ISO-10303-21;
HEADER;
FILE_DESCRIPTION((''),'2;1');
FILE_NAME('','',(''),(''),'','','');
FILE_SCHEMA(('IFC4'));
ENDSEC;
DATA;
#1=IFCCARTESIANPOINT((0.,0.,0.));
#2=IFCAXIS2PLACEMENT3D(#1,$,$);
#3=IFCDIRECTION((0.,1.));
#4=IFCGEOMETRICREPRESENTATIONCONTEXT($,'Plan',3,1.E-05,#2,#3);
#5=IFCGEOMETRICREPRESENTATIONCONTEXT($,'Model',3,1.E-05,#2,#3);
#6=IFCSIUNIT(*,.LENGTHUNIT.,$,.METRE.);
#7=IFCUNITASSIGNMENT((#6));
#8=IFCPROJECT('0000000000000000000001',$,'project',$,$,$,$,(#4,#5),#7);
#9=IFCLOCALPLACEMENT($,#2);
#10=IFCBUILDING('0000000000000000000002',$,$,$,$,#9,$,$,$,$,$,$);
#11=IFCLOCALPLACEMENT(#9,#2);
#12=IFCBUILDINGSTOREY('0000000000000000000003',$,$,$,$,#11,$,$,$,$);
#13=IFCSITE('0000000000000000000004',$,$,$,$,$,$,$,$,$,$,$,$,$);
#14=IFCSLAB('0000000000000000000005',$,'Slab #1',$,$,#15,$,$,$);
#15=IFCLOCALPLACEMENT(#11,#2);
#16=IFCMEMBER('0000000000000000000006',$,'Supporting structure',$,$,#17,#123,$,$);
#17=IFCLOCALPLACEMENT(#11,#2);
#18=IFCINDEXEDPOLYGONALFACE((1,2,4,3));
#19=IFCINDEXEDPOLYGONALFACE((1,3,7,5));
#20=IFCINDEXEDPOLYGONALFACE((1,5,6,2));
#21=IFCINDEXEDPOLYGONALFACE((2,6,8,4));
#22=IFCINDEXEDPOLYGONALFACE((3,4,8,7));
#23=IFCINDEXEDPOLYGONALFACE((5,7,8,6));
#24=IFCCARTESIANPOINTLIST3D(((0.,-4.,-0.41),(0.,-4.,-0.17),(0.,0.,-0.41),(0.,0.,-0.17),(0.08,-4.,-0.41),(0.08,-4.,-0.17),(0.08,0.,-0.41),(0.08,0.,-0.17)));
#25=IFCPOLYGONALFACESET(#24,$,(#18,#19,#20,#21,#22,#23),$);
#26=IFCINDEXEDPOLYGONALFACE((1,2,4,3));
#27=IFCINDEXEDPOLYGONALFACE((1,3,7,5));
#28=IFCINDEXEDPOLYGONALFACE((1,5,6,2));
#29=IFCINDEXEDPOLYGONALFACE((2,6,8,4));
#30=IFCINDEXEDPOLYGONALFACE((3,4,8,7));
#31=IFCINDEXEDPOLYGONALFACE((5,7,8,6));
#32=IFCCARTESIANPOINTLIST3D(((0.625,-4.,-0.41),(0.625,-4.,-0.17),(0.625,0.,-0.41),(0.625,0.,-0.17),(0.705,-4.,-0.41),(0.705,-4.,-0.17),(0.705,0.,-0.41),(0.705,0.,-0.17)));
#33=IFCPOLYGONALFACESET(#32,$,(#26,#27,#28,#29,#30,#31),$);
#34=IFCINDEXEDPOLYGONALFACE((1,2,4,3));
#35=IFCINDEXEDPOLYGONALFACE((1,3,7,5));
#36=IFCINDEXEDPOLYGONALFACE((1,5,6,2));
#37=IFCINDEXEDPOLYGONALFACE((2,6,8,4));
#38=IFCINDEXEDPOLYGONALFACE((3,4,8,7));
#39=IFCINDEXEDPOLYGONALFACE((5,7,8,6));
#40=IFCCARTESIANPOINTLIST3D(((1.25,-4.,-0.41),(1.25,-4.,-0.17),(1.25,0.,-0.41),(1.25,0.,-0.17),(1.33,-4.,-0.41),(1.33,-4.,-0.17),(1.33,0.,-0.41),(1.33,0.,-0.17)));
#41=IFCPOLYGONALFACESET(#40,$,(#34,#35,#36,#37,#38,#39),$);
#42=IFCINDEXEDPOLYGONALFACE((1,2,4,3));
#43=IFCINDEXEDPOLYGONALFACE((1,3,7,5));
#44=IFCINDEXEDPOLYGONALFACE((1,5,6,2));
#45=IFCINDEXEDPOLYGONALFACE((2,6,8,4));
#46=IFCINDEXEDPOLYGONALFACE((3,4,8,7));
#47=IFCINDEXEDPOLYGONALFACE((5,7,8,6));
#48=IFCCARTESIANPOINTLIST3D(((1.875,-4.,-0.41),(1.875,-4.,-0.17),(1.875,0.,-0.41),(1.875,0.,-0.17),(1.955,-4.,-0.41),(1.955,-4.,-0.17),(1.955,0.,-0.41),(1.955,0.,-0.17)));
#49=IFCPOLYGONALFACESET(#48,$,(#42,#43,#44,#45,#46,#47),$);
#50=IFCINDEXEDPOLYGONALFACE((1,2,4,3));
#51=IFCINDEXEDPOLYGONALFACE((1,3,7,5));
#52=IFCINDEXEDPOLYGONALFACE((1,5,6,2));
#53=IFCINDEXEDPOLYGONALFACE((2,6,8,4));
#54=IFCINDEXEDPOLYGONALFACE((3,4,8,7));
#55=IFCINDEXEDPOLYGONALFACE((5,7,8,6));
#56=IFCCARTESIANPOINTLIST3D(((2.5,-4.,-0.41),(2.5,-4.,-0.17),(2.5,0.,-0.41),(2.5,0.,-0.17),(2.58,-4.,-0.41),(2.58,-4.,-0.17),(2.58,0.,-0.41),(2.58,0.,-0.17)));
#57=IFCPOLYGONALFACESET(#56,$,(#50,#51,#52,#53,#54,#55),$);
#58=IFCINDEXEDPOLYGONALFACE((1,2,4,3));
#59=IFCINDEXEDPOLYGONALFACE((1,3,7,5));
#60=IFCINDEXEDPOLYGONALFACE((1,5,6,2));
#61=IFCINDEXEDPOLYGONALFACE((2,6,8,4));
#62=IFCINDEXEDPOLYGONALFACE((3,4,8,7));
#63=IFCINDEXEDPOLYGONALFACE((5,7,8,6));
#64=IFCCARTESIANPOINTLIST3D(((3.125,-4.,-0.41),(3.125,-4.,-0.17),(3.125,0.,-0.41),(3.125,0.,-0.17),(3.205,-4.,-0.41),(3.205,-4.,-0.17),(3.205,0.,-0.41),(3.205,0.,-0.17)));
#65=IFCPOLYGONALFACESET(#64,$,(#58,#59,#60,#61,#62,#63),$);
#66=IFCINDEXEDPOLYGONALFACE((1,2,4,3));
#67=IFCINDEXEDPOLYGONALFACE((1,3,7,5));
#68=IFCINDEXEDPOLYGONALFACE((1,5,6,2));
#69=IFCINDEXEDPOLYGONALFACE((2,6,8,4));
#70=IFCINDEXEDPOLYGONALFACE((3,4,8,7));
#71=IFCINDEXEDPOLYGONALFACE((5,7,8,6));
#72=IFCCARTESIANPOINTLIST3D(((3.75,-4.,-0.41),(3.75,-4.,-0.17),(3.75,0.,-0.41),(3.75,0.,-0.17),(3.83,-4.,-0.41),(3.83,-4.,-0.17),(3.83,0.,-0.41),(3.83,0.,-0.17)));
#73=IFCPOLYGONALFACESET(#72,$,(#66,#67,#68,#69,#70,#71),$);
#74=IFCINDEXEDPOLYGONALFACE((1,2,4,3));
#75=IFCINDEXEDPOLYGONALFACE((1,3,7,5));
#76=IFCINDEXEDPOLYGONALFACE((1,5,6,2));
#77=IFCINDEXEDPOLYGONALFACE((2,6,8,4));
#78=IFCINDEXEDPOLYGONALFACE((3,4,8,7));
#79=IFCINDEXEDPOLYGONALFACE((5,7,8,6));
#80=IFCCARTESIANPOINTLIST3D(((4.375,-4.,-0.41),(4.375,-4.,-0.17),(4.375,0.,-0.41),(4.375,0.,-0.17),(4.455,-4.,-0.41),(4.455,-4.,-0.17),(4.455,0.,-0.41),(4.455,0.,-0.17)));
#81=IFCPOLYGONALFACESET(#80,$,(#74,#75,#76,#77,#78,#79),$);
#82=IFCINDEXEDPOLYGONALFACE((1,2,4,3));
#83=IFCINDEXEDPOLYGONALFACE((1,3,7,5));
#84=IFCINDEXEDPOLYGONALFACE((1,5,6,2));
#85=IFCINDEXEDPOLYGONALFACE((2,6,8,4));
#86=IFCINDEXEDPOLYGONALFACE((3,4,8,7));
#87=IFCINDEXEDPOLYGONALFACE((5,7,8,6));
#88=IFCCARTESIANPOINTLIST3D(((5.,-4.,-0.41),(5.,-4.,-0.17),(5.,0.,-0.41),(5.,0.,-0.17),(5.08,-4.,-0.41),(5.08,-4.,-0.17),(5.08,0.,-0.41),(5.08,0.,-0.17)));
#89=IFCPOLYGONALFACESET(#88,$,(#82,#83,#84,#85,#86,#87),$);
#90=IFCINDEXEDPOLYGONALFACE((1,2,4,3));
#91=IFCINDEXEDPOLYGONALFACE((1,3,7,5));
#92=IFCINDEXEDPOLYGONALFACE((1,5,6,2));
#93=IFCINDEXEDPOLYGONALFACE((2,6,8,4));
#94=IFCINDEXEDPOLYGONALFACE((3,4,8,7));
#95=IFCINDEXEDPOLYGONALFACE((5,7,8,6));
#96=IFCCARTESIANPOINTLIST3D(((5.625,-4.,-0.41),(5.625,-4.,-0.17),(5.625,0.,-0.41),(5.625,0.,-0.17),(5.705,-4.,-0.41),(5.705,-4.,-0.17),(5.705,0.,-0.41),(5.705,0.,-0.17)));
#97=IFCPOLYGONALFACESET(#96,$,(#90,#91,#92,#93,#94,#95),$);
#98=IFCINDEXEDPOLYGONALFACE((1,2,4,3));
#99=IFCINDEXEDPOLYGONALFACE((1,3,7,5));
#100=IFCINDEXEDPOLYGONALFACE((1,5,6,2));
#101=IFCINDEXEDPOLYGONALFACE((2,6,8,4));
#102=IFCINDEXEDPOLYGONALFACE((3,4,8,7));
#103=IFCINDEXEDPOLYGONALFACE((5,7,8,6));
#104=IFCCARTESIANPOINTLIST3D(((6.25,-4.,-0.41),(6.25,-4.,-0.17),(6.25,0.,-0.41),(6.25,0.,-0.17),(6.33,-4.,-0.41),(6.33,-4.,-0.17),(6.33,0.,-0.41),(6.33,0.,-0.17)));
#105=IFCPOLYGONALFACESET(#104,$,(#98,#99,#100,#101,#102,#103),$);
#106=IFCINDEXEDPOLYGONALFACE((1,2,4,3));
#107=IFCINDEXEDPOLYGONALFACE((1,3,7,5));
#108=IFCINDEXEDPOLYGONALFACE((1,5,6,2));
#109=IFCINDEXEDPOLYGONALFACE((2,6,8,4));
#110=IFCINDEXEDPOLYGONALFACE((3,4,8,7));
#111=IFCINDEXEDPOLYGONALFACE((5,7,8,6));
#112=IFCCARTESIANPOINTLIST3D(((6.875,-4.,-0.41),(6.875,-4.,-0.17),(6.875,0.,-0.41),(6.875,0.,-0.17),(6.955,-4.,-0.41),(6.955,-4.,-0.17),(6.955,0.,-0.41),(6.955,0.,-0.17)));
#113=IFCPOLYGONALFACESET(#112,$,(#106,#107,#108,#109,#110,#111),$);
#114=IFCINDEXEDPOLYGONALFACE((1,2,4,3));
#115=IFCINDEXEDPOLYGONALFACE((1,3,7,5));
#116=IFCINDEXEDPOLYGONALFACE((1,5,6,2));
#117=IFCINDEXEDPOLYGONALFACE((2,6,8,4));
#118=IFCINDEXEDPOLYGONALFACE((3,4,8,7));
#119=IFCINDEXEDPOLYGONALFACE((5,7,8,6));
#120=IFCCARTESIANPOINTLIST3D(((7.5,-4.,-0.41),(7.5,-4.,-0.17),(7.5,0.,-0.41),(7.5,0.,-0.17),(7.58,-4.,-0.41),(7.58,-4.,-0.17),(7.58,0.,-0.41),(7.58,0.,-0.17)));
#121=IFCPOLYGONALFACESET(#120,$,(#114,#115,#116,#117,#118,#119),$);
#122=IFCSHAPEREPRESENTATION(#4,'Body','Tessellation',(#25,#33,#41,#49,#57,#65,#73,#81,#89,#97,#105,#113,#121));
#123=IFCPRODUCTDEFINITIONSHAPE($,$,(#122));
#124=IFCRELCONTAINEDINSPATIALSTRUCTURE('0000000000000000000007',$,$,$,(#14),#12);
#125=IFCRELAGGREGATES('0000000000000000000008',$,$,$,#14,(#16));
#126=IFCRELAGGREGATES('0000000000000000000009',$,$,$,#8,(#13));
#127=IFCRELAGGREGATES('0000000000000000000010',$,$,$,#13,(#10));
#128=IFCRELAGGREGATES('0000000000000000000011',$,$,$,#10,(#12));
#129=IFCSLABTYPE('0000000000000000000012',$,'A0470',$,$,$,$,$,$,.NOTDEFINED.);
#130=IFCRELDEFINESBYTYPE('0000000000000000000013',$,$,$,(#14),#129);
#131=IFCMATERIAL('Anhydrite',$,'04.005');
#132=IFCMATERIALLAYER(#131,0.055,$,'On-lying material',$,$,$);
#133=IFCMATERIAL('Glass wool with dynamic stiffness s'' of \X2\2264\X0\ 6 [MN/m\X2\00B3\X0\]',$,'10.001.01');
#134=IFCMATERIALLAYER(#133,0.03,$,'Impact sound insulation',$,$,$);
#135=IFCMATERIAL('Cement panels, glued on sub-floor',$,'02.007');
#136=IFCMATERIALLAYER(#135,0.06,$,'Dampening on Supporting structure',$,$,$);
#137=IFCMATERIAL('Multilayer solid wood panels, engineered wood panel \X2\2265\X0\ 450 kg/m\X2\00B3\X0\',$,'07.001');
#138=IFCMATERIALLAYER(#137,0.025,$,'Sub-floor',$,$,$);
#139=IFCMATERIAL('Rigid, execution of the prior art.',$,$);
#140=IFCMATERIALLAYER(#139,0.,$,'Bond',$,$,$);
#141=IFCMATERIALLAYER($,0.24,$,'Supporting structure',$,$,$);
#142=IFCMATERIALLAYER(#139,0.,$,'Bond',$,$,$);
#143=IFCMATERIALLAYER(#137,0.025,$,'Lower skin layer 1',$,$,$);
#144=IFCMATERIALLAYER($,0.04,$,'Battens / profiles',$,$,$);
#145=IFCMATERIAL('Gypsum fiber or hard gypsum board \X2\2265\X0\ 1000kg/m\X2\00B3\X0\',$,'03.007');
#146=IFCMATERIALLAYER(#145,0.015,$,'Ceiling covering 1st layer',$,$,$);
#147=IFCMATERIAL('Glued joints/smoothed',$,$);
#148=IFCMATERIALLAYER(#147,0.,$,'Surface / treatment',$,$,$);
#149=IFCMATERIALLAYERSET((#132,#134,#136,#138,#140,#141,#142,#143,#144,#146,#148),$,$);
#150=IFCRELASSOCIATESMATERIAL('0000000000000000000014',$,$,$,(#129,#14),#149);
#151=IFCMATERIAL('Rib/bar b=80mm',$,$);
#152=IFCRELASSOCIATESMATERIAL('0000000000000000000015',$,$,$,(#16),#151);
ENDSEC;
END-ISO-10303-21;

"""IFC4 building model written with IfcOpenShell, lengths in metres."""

from ifc_helpers import new_model, si_unit, direction, frame, frame_2d, origin, place, context, project, spatial, rectangle, extrude, material, layer, layer_set, type_object, element, aggregate, save


model = new_model("IFC4")

# Units and contexts
plan_context = context("Plan", 3, precision=1e-05, world=origin(), true_north=direction((0.0, 1.0)))
model_context = context("Model", 3, precision=1e-05, world=origin(), true_north=direction((0.0, 1.0)))
ifc_project = project(units=[si_unit("LENGTHUNIT", "METRE")], contexts=[plan_context, model_context])

# Site, building, storey
site = spatial("IfcSite", under=ifc_project)
building_placement = place(None, origin())
building = spatial("IfcBuilding", under=site, at=building_placement)
storey_placement = place(building_placement, origin())
storey = spatial("IfcBuildingStorey", under=building, at=storey_placement)

# Slab, member
ifc_material_1 = material(Name="Anhydrite", Category="04.005")
ifc_layer_1 = layer(ifc_material_1, 0.055, Name="On-lying material")
ifc_material_2 = material(Name="Glass wool with dynamic stiffness s' of ≤ 6 [MN/m³]", Category="10.001.01")
ifc_layer_2 = layer(ifc_material_2, 0.03, Name="Impact sound insulation")
ifc_material_3 = material(Name="Cement panels, glued on sub-floor", Category="02.007")
ifc_layer_3 = layer(ifc_material_3, 0.06, Name="Dampening on Supporting structure")
ifc_material_4 = material(Name="Multilayer solid wood panels, engineered wood panel ≥ 450 kg/m³", Category="07.001")
ifc_layer_4 = layer(ifc_material_4, 0.025, Name="Sub-floor")
ifc_material_5 = material(Name="Rigid, execution of the prior art.")
ifc_layer_5 = layer(ifc_material_5, 0.0, Name="Bond")
ifc_layer_6 = layer(None, 0.24, Name="Supporting structure")
ifc_layer_7 = layer(ifc_material_5, 0.0, Name="Bond")
ifc_layer_8 = layer(ifc_material_4, 0.025, Name="Lower skin layer 1")
ifc_layer_9 = layer(None, 0.04, Name="Battens / profiles")
ifc_material_6 = material(Name="Gypsum fiber or hard gypsum board ≥ 1000kg/m³", Category="03.007")
ifc_layer_10 = layer(ifc_material_6, 0.015, Name="Ceiling covering 1st layer")
ifc_material_7 = material(Name="Glued joints/smoothed")
ifc_layer_11 = layer(ifc_material_7, 0.0, Name="Surface / treatment")
ifc_layer_set = layer_set([ifc_layer_1, ifc_layer_2, ifc_layer_3, ifc_layer_4, ifc_layer_5, ifc_layer_6, ifc_layer_7, ifc_layer_8, ifc_layer_9, ifc_layer_10, ifc_layer_11])
slab_type = type_object("IfcSlabType", Name="A0470", PredefinedType="NOTDEFINED", material=ifc_layer_set)
slab_placement = place(None, frame((0.0, 0.0, 0.0), z_axis=(0.0, 0.0, -1.0), x_axis=(1.0, 0.0, 0.0)))
slab = element("IfcSlab", 1, at=slab_placement, inside=storey, type_object=slab_type, material=ifc_layer_set, Name="Slab #1")
ifc_material_8 = material(Name="Rib/bar b=80mm")
member_1_placement = place(slab_placement, origin())
member_1 = element("IfcMember", 2, at=member_1_placement, material=ifc_material_8, Name="Supporting structure", context=plan_context, shape_type="SweptSolid", body=[
    extrude(rectangle(XDim=0.08, YDim=0.24, at=frame_2d((0.04, 0.12), x_axis=(1.0, 0.0))), frame((0.0, 4.0, 0.17), z_axis=(0.0, -1.0, 0.0), x_axis=(1.0, 0.0, 0.0)), (0.0, 0.0, 1.0), 4.0),
    extrude(rectangle(XDim=0.08, YDim=0.24, at=frame_2d((0.04, 0.12), x_axis=(1.0, 0.0))), frame((0.625, 4.0, 0.17), z_axis=(0.0, -1.0, 0.0), x_axis=(1.0, 0.0, 0.0)), (0.0, 0.0, 1.0), 4.0),
    extrude(rectangle(XDim=0.08, YDim=0.24, at=frame_2d((0.04, 0.12), x_axis=(1.0, 0.0))), frame((1.25, 4.0, 0.17), z_axis=(0.0, -1.0, 0.0), x_axis=(1.0, 0.0, 0.0)), (0.0, 0.0, 1.0), 4.0),
    extrude(rectangle(XDim=0.08, YDim=0.24, at=frame_2d((0.04, 0.12), x_axis=(1.0, 0.0))), frame((1.875, 4.0, 0.17), z_axis=(0.0, -1.0, 0.0), x_axis=(1.0, 0.0, 0.0)), (0.0, 0.0, 1.0), 4.0),
    extrude(rectangle(XDim=0.08, YDim=0.24, at=frame_2d((0.04, 0.12), x_axis=(1.0, 0.0))), frame((2.5, 4.0, 0.17), z_axis=(0.0, -1.0, 0.0), x_axis=(1.0, 0.0, 0.0)), (0.0, 0.0, 1.0), 4.0),
    extrude(rectangle(XDim=0.08, YDim=0.24, at=frame_2d((0.04, 0.12), x_axis=(1.0, 0.0))), frame((3.125, 4.0, 0.17), z_axis=(0.0, -1.0, 0.0), x_axis=(1.0, 0.0, 0.0)), (0.0, 0.0, 1.0), 4.0),
    extrude(rectangle(XDim=0.08, YDim=0.24, at=frame_2d((0.04, 0.12), x_axis=(1.0, 0.0))), frame((3.75, 4.0, 0.17), z_axis=(0.0, -1.0, 0.0), x_axis=(1.0, 0.0, 0.0)), (0.0, 0.0, 1.0), 4.0),
    extrude(rectangle(XDim=0.08, YDim=0.24, at=frame_2d((0.04, 0.12), x_axis=(1.0, 0.0))), frame((4.375, 4.0, 0.17), z_axis=(0.0, -1.0, 0.0), x_axis=(1.0, 0.0, 0.0)), (0.0, 0.0, 1.0), 4.0),
    extrude(rectangle(XDim=0.08, YDim=0.24, at=frame_2d((0.04, 0.12), x_axis=(1.0, 0.0))), frame((5.0, 4.0, 0.17), z_axis=(0.0, -1.0, 0.0), x_axis=(1.0, 0.0, 0.0)), (0.0, 0.0, 1.0), 4.0),
    extrude(rectangle(XDim=0.08, YDim=0.24, at=frame_2d((0.04, 0.12), x_axis=(1.0, 0.0))), frame((5.625, 4.0, 0.17), z_axis=(0.0, -1.0, 0.0), x_axis=(1.0, 0.0, 0.0)), (0.0, 0.0, 1.0), 4.0),
    extrude(rectangle(XDim=0.08, YDim=0.24, at=frame_2d((0.04, 0.12), x_axis=(1.0, 0.0))), frame((6.25, 4.0, 0.17), z_axis=(0.0, -1.0, 0.0), x_axis=(1.0, 0.0, 0.0)), (0.0, 0.0, 1.0), 4.0),
    extrude(rectangle(XDim=0.08, YDim=0.24, at=frame_2d((0.04, 0.12), x_axis=(1.0, 0.0))), frame((6.875, 4.0, 0.17), z_axis=(0.0, -1.0, 0.0), x_axis=(1.0, 0.0, 0.0)), (0.0, 0.0, 1.0), 4.0),
    extrude(rectangle(XDim=0.08, YDim=0.24, at=frame_2d((0.04, 0.12), x_axis=(1.0, 0.0))), frame((7.5, 4.0, 0.17), z_axis=(0.0, -1.0, 0.0), x_axis=(1.0, 0.0, 0.0)), (0.0, 0.0, 1.0), 4.0),
])
aggregate(slab, [member_1])

save(model, "model.ifc")
